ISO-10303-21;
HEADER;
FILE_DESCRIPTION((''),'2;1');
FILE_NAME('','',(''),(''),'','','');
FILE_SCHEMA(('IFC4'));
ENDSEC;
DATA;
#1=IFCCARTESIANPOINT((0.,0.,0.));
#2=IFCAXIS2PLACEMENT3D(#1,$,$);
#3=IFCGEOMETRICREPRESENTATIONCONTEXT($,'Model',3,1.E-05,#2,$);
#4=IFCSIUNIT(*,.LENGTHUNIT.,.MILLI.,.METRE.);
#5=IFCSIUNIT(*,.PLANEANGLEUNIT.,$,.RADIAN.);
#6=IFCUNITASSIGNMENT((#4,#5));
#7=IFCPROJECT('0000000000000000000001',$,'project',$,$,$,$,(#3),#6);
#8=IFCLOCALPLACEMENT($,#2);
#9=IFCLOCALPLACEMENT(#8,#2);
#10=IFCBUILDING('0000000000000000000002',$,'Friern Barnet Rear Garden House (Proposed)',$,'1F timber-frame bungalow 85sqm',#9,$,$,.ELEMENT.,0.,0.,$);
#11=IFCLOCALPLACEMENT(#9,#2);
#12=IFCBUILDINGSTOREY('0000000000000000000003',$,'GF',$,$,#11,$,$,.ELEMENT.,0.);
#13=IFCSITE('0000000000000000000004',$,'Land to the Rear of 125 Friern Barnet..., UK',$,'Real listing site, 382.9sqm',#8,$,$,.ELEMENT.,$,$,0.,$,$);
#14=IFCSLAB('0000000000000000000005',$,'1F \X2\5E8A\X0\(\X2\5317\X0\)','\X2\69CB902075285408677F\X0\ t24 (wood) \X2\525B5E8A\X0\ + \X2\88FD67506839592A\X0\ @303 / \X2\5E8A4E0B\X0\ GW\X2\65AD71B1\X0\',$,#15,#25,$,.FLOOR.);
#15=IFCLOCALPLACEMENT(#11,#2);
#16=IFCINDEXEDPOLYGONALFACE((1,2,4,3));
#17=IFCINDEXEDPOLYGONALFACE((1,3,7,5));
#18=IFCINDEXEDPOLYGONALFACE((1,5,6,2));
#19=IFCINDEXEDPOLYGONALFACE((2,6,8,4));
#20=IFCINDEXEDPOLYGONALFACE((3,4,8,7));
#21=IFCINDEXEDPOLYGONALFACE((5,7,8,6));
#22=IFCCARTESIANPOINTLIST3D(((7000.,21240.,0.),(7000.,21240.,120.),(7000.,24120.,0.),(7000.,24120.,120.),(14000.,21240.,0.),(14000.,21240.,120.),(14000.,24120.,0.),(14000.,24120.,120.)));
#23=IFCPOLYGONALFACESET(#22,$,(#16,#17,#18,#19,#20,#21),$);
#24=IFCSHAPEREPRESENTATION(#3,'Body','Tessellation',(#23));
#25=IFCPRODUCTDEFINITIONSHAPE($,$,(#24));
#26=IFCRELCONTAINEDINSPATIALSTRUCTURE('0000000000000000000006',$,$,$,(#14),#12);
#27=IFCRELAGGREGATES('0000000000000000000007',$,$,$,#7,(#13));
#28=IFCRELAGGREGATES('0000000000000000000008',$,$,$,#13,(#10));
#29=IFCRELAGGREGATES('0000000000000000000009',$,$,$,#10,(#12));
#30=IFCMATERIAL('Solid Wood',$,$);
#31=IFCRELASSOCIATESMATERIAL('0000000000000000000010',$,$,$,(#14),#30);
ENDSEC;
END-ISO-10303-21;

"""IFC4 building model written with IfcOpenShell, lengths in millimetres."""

from ifc_helpers import new_model, si_unit, frame, frame_2d, origin, place, context, project, spatial, rectangle, extrude, material, element, save


model = new_model("IFC4")

# Units and contexts
model_context = context("Model", 3, precision=1e-05, world=origin())
ifc_project = project(units=[si_unit("LENGTHUNIT", "METRE", prefix="MILLI"), si_unit("PLANEANGLEUNIT", "RADIAN")], contexts=[model_context])

# Site, building, storey
site_placement = place(None, origin())
site = spatial("IfcSite", under=ifc_project, at=site_placement, Name="Land to the Rear of 125 Friern Barnet..., UK", ObjectType="Real listing site, 382.9sqm", CompositionType="ELEMENT", RefElevation=0.0)
building_placement = place(site_placement, origin())
building = spatial("IfcBuilding", under=site, at=building_placement, Name="Friern Barnet Rear Garden House (Proposed)", ObjectType="1F timber-frame bungalow 85sqm", CompositionType="ELEMENT", ElevationOfRefHeight=0.0, ElevationOfTerrain=0.0)
storey_placement = place(building_placement, origin())
storey = spatial("IfcBuildingStorey", under=building, at=storey_placement, Name="GF", CompositionType="ELEMENT", Elevation=0.0)

# Slab
ifc_material_1 = material(Name="Solid Wood")
slab_1_placement = place(storey_placement, frame((3500.0, 10620.0, 0.0)))
element("IfcSlab", 1, at=slab_1_placement, inside=storey, material=ifc_material_1, Name="1F 床(北)", Description="構造用合板 t24 (wood) 剛床 + 製材根太 @303 / 床下 GW断熱", PredefinedType="FLOOR", context=model_context, shape_type="SweptSolid", body=[
    extrude(rectangle(XDim=7000.0, YDim=2880.0, at=frame_2d((3500.0, 1440.0))), frame((3500.0, 10620.0, 0.0)), (0.0, 0.0, 1.0), 120.0),
])

save(model, "model.ifc")
